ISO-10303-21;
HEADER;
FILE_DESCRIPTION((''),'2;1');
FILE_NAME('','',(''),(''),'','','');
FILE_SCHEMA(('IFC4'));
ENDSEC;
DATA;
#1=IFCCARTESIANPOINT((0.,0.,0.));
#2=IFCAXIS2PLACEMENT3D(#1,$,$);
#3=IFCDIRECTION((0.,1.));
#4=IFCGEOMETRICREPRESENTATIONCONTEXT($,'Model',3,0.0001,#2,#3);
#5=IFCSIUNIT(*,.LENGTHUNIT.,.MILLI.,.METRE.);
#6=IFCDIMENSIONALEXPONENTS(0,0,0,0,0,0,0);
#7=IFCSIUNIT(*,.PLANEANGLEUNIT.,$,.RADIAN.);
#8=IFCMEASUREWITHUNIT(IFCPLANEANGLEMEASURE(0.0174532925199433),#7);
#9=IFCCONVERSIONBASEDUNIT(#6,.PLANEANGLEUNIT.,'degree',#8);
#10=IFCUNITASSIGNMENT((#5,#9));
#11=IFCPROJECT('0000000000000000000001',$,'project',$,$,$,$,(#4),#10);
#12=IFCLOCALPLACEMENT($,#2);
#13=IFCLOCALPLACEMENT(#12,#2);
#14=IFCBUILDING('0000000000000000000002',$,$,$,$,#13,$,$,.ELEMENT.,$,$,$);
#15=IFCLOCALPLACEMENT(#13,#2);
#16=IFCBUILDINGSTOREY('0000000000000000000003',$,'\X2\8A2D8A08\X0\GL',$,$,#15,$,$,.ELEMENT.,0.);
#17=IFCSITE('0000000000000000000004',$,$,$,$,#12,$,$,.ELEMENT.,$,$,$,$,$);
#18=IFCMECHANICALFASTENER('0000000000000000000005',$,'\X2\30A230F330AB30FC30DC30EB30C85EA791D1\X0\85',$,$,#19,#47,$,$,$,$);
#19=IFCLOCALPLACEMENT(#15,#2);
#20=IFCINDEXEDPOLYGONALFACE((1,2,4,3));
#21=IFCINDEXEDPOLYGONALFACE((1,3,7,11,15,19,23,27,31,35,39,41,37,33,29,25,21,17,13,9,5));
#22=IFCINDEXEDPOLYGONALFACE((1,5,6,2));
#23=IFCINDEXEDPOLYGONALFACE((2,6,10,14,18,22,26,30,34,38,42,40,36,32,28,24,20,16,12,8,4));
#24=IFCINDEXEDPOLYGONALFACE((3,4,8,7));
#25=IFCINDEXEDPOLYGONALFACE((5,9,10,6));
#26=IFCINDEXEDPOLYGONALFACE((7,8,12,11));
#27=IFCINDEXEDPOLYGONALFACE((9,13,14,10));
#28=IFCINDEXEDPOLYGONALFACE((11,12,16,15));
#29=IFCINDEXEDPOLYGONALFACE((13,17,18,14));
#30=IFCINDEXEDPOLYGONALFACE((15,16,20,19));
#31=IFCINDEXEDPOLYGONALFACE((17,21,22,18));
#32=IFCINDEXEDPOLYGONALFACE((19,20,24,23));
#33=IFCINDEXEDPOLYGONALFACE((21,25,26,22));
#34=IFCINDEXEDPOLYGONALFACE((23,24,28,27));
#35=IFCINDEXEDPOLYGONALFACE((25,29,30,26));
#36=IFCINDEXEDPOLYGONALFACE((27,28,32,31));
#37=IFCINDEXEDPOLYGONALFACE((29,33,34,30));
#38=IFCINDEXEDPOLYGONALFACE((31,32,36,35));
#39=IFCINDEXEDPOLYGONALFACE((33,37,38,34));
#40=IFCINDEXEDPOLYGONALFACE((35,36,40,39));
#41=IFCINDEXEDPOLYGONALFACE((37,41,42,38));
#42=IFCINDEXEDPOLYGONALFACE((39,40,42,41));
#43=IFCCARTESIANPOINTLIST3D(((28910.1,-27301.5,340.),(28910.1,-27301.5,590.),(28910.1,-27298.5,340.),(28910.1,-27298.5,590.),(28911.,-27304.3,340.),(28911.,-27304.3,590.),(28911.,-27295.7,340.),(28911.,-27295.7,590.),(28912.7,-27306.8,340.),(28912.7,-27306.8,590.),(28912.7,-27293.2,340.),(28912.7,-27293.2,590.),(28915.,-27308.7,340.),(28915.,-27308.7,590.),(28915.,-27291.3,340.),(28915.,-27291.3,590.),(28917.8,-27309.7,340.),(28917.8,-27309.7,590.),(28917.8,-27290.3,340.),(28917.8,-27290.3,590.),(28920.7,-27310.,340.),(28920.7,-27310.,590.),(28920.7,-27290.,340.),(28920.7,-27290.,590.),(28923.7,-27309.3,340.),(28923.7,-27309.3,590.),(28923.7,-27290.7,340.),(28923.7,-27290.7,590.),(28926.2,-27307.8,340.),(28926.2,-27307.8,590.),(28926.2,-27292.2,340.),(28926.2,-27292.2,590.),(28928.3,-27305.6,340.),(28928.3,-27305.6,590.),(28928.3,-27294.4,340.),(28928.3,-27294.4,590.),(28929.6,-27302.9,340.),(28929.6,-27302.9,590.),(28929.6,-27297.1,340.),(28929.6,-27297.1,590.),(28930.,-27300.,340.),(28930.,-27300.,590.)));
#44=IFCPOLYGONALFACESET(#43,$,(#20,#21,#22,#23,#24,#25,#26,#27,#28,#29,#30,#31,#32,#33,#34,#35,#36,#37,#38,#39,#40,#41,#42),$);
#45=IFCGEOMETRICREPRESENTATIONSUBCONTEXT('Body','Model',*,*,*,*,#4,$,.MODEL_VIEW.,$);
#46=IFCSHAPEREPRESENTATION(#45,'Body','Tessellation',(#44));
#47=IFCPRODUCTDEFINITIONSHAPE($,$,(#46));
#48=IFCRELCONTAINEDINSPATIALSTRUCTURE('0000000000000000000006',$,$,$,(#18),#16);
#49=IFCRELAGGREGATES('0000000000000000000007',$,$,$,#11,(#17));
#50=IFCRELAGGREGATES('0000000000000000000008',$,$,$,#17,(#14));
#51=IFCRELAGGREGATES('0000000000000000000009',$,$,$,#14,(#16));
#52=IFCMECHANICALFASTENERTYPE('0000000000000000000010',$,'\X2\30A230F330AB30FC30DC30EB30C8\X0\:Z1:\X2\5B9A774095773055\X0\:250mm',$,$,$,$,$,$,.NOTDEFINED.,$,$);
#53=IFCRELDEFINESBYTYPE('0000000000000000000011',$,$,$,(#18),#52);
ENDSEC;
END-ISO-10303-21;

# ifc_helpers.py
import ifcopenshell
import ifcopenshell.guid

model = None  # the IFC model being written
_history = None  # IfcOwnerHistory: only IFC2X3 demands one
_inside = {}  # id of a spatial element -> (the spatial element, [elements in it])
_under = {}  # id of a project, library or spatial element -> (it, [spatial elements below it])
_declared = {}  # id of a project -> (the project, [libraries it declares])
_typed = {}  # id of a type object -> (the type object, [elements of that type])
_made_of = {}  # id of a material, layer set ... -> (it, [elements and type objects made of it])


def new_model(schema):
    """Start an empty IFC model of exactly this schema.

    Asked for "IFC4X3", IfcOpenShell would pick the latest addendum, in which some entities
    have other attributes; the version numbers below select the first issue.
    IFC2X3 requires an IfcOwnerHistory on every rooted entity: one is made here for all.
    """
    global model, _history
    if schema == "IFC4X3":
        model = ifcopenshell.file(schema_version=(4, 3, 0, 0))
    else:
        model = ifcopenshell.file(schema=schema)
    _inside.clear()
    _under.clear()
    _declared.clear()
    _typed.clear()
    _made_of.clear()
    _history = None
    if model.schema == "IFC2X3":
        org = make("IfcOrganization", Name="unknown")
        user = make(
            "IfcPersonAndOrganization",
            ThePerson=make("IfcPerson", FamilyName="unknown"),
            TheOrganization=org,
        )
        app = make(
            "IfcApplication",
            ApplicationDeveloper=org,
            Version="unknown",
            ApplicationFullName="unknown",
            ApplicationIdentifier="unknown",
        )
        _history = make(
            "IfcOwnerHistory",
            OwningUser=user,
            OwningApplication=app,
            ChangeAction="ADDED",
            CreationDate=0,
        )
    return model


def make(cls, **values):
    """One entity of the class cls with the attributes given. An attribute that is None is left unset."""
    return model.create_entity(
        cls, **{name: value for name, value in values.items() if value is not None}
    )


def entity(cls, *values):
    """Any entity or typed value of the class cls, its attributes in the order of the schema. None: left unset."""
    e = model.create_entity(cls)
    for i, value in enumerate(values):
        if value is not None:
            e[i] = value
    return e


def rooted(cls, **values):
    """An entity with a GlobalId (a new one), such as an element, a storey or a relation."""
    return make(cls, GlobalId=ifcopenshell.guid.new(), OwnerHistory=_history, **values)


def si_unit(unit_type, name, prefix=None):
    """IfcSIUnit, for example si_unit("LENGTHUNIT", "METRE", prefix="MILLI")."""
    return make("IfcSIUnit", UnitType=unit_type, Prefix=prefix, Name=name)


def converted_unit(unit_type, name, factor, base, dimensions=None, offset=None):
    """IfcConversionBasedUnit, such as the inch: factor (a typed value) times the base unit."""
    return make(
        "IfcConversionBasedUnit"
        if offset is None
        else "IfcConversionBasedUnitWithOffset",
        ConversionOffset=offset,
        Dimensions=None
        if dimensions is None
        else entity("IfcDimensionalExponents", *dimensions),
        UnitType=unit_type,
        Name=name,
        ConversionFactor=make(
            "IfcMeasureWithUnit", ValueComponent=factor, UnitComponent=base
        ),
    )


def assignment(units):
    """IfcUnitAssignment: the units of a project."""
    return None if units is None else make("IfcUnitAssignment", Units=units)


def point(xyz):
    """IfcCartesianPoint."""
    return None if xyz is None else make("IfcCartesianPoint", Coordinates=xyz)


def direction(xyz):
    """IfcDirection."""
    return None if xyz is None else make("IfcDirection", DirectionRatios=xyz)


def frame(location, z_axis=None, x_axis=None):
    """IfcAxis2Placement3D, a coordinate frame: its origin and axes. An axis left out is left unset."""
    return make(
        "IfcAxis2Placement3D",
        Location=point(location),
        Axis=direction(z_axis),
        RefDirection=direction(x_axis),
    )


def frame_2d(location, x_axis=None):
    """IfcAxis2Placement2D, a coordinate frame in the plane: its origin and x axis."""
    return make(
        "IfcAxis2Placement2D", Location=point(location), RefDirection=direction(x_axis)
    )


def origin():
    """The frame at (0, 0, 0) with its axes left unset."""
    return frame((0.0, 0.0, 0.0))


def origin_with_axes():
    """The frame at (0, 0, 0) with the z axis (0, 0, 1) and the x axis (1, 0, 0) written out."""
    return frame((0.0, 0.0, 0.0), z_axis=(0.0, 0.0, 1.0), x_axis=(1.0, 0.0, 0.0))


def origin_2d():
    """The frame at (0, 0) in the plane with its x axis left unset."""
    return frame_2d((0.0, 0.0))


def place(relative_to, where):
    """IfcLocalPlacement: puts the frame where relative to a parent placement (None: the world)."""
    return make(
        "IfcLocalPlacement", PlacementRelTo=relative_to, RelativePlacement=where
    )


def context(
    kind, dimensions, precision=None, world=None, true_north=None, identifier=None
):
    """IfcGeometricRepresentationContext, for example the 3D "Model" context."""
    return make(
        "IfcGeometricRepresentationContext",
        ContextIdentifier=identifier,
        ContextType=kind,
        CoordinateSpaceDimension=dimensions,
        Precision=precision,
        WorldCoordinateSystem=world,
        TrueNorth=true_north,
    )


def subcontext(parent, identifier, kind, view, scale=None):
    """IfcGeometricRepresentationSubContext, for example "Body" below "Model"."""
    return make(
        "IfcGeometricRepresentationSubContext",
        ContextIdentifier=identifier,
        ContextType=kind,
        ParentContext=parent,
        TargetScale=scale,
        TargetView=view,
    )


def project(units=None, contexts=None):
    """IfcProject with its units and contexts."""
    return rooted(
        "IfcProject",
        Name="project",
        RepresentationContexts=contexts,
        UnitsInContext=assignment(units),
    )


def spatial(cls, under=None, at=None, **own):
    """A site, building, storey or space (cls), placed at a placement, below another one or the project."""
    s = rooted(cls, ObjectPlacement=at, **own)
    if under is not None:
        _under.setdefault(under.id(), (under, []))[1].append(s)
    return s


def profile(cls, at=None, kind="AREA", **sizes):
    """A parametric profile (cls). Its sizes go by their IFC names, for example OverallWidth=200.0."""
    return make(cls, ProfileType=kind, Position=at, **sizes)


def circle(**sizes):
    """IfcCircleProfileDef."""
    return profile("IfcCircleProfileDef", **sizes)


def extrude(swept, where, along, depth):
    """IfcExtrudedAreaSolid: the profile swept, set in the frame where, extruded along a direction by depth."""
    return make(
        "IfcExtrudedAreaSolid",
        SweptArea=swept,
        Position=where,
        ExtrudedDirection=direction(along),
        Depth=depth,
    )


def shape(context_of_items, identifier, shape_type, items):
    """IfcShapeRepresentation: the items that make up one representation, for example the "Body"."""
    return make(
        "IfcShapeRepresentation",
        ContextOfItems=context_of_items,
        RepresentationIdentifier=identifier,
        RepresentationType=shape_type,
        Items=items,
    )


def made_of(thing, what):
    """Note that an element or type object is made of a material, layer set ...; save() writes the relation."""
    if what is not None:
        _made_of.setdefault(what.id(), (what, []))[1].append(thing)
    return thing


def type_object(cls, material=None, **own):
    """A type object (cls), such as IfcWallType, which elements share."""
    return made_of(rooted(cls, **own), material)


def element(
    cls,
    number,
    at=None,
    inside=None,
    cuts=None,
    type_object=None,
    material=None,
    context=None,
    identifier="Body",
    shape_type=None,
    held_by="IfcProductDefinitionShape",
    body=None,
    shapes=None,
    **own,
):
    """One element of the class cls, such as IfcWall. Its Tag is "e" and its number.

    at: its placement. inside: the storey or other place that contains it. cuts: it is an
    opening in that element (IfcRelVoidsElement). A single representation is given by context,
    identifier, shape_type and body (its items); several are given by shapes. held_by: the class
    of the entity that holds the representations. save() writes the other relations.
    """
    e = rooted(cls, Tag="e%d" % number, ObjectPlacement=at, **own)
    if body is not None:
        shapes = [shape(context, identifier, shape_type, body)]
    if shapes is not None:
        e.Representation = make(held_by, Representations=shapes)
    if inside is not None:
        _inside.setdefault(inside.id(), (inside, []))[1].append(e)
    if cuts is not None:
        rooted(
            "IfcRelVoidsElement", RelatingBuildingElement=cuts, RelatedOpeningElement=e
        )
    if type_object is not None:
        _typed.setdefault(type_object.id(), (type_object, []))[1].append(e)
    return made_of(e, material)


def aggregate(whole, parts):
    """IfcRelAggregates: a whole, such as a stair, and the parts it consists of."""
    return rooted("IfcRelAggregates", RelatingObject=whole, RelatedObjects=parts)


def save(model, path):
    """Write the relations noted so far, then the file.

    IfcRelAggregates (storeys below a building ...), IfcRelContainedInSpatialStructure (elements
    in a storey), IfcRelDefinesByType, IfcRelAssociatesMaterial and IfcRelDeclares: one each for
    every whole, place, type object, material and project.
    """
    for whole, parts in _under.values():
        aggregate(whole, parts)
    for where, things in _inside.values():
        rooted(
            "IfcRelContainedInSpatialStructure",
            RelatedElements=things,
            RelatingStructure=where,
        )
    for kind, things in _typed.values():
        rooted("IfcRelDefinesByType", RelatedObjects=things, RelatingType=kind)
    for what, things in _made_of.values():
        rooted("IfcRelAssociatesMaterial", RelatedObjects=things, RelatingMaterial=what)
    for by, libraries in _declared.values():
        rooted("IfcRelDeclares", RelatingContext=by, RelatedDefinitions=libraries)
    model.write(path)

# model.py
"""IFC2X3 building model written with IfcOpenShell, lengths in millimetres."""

from ifc_helpers import new_model, entity, si_unit, converted_unit, direction, frame, origin, origin_with_axes, origin_2d, place, context, subcontext, project, spatial, circle, extrude, type_object, element, save


model = new_model("IFC2X3")

# Units and contexts
model_context = context("Model", 3, precision=0.0001, world=origin(), true_north=direction((0.0, 1.0)))
body_context = subcontext(model_context, "Body", "Model", "MODEL_VIEW")
ifc_project = project(units=[si_unit("LENGTHUNIT", "METRE", prefix="MILLI"), converted_unit("PLANEANGLEUNIT", "degree", entity("IfcPlaneAngleMeasure", 0.0174532925199433), si_unit("PLANEANGLEUNIT", "RADIAN"), dimensions=[0, 0, 0, 0, 0, 0, 0])], contexts=[model_context])

# Site, building, storey
site_placement = place(None, origin())
site = spatial("IfcSite", under=ifc_project, at=site_placement, CompositionType="ELEMENT")
building_placement = place(site_placement, origin())
building = spatial("IfcBuilding", under=site, at=building_placement, CompositionType="ELEMENT")
storey_placement = place(building_placement, origin())
storey = spatial("IfcBuildingStorey", under=building, at=storey_placement, Name="設計GL", CompositionType="ELEMENT", Elevation=0.0)

# Mechanical fastener
mechanical_fastener_type_1 = type_object("IfcMechanicalFastenerType", Name="アンカーボルト:Z1:定着長さ:250mm")
mechanical_fastener_1_placement = place(storey_placement, frame((28920.0, -27300.0, 340.0)))
element("IfcMechanicalFastener", 1, at=mechanical_fastener_1_placement, inside=storey, type_object=mechanical_fastener_type_1, Name="アンカーボルト座金85", context=body_context, shape_type="SweptSolid", body=[
    extrude(circle(Radius=10.0, at=origin_2d()), origin_with_axes(), (0.0, 0.0, 1.0), 250.0),
])

save(model, "model.ifc")
